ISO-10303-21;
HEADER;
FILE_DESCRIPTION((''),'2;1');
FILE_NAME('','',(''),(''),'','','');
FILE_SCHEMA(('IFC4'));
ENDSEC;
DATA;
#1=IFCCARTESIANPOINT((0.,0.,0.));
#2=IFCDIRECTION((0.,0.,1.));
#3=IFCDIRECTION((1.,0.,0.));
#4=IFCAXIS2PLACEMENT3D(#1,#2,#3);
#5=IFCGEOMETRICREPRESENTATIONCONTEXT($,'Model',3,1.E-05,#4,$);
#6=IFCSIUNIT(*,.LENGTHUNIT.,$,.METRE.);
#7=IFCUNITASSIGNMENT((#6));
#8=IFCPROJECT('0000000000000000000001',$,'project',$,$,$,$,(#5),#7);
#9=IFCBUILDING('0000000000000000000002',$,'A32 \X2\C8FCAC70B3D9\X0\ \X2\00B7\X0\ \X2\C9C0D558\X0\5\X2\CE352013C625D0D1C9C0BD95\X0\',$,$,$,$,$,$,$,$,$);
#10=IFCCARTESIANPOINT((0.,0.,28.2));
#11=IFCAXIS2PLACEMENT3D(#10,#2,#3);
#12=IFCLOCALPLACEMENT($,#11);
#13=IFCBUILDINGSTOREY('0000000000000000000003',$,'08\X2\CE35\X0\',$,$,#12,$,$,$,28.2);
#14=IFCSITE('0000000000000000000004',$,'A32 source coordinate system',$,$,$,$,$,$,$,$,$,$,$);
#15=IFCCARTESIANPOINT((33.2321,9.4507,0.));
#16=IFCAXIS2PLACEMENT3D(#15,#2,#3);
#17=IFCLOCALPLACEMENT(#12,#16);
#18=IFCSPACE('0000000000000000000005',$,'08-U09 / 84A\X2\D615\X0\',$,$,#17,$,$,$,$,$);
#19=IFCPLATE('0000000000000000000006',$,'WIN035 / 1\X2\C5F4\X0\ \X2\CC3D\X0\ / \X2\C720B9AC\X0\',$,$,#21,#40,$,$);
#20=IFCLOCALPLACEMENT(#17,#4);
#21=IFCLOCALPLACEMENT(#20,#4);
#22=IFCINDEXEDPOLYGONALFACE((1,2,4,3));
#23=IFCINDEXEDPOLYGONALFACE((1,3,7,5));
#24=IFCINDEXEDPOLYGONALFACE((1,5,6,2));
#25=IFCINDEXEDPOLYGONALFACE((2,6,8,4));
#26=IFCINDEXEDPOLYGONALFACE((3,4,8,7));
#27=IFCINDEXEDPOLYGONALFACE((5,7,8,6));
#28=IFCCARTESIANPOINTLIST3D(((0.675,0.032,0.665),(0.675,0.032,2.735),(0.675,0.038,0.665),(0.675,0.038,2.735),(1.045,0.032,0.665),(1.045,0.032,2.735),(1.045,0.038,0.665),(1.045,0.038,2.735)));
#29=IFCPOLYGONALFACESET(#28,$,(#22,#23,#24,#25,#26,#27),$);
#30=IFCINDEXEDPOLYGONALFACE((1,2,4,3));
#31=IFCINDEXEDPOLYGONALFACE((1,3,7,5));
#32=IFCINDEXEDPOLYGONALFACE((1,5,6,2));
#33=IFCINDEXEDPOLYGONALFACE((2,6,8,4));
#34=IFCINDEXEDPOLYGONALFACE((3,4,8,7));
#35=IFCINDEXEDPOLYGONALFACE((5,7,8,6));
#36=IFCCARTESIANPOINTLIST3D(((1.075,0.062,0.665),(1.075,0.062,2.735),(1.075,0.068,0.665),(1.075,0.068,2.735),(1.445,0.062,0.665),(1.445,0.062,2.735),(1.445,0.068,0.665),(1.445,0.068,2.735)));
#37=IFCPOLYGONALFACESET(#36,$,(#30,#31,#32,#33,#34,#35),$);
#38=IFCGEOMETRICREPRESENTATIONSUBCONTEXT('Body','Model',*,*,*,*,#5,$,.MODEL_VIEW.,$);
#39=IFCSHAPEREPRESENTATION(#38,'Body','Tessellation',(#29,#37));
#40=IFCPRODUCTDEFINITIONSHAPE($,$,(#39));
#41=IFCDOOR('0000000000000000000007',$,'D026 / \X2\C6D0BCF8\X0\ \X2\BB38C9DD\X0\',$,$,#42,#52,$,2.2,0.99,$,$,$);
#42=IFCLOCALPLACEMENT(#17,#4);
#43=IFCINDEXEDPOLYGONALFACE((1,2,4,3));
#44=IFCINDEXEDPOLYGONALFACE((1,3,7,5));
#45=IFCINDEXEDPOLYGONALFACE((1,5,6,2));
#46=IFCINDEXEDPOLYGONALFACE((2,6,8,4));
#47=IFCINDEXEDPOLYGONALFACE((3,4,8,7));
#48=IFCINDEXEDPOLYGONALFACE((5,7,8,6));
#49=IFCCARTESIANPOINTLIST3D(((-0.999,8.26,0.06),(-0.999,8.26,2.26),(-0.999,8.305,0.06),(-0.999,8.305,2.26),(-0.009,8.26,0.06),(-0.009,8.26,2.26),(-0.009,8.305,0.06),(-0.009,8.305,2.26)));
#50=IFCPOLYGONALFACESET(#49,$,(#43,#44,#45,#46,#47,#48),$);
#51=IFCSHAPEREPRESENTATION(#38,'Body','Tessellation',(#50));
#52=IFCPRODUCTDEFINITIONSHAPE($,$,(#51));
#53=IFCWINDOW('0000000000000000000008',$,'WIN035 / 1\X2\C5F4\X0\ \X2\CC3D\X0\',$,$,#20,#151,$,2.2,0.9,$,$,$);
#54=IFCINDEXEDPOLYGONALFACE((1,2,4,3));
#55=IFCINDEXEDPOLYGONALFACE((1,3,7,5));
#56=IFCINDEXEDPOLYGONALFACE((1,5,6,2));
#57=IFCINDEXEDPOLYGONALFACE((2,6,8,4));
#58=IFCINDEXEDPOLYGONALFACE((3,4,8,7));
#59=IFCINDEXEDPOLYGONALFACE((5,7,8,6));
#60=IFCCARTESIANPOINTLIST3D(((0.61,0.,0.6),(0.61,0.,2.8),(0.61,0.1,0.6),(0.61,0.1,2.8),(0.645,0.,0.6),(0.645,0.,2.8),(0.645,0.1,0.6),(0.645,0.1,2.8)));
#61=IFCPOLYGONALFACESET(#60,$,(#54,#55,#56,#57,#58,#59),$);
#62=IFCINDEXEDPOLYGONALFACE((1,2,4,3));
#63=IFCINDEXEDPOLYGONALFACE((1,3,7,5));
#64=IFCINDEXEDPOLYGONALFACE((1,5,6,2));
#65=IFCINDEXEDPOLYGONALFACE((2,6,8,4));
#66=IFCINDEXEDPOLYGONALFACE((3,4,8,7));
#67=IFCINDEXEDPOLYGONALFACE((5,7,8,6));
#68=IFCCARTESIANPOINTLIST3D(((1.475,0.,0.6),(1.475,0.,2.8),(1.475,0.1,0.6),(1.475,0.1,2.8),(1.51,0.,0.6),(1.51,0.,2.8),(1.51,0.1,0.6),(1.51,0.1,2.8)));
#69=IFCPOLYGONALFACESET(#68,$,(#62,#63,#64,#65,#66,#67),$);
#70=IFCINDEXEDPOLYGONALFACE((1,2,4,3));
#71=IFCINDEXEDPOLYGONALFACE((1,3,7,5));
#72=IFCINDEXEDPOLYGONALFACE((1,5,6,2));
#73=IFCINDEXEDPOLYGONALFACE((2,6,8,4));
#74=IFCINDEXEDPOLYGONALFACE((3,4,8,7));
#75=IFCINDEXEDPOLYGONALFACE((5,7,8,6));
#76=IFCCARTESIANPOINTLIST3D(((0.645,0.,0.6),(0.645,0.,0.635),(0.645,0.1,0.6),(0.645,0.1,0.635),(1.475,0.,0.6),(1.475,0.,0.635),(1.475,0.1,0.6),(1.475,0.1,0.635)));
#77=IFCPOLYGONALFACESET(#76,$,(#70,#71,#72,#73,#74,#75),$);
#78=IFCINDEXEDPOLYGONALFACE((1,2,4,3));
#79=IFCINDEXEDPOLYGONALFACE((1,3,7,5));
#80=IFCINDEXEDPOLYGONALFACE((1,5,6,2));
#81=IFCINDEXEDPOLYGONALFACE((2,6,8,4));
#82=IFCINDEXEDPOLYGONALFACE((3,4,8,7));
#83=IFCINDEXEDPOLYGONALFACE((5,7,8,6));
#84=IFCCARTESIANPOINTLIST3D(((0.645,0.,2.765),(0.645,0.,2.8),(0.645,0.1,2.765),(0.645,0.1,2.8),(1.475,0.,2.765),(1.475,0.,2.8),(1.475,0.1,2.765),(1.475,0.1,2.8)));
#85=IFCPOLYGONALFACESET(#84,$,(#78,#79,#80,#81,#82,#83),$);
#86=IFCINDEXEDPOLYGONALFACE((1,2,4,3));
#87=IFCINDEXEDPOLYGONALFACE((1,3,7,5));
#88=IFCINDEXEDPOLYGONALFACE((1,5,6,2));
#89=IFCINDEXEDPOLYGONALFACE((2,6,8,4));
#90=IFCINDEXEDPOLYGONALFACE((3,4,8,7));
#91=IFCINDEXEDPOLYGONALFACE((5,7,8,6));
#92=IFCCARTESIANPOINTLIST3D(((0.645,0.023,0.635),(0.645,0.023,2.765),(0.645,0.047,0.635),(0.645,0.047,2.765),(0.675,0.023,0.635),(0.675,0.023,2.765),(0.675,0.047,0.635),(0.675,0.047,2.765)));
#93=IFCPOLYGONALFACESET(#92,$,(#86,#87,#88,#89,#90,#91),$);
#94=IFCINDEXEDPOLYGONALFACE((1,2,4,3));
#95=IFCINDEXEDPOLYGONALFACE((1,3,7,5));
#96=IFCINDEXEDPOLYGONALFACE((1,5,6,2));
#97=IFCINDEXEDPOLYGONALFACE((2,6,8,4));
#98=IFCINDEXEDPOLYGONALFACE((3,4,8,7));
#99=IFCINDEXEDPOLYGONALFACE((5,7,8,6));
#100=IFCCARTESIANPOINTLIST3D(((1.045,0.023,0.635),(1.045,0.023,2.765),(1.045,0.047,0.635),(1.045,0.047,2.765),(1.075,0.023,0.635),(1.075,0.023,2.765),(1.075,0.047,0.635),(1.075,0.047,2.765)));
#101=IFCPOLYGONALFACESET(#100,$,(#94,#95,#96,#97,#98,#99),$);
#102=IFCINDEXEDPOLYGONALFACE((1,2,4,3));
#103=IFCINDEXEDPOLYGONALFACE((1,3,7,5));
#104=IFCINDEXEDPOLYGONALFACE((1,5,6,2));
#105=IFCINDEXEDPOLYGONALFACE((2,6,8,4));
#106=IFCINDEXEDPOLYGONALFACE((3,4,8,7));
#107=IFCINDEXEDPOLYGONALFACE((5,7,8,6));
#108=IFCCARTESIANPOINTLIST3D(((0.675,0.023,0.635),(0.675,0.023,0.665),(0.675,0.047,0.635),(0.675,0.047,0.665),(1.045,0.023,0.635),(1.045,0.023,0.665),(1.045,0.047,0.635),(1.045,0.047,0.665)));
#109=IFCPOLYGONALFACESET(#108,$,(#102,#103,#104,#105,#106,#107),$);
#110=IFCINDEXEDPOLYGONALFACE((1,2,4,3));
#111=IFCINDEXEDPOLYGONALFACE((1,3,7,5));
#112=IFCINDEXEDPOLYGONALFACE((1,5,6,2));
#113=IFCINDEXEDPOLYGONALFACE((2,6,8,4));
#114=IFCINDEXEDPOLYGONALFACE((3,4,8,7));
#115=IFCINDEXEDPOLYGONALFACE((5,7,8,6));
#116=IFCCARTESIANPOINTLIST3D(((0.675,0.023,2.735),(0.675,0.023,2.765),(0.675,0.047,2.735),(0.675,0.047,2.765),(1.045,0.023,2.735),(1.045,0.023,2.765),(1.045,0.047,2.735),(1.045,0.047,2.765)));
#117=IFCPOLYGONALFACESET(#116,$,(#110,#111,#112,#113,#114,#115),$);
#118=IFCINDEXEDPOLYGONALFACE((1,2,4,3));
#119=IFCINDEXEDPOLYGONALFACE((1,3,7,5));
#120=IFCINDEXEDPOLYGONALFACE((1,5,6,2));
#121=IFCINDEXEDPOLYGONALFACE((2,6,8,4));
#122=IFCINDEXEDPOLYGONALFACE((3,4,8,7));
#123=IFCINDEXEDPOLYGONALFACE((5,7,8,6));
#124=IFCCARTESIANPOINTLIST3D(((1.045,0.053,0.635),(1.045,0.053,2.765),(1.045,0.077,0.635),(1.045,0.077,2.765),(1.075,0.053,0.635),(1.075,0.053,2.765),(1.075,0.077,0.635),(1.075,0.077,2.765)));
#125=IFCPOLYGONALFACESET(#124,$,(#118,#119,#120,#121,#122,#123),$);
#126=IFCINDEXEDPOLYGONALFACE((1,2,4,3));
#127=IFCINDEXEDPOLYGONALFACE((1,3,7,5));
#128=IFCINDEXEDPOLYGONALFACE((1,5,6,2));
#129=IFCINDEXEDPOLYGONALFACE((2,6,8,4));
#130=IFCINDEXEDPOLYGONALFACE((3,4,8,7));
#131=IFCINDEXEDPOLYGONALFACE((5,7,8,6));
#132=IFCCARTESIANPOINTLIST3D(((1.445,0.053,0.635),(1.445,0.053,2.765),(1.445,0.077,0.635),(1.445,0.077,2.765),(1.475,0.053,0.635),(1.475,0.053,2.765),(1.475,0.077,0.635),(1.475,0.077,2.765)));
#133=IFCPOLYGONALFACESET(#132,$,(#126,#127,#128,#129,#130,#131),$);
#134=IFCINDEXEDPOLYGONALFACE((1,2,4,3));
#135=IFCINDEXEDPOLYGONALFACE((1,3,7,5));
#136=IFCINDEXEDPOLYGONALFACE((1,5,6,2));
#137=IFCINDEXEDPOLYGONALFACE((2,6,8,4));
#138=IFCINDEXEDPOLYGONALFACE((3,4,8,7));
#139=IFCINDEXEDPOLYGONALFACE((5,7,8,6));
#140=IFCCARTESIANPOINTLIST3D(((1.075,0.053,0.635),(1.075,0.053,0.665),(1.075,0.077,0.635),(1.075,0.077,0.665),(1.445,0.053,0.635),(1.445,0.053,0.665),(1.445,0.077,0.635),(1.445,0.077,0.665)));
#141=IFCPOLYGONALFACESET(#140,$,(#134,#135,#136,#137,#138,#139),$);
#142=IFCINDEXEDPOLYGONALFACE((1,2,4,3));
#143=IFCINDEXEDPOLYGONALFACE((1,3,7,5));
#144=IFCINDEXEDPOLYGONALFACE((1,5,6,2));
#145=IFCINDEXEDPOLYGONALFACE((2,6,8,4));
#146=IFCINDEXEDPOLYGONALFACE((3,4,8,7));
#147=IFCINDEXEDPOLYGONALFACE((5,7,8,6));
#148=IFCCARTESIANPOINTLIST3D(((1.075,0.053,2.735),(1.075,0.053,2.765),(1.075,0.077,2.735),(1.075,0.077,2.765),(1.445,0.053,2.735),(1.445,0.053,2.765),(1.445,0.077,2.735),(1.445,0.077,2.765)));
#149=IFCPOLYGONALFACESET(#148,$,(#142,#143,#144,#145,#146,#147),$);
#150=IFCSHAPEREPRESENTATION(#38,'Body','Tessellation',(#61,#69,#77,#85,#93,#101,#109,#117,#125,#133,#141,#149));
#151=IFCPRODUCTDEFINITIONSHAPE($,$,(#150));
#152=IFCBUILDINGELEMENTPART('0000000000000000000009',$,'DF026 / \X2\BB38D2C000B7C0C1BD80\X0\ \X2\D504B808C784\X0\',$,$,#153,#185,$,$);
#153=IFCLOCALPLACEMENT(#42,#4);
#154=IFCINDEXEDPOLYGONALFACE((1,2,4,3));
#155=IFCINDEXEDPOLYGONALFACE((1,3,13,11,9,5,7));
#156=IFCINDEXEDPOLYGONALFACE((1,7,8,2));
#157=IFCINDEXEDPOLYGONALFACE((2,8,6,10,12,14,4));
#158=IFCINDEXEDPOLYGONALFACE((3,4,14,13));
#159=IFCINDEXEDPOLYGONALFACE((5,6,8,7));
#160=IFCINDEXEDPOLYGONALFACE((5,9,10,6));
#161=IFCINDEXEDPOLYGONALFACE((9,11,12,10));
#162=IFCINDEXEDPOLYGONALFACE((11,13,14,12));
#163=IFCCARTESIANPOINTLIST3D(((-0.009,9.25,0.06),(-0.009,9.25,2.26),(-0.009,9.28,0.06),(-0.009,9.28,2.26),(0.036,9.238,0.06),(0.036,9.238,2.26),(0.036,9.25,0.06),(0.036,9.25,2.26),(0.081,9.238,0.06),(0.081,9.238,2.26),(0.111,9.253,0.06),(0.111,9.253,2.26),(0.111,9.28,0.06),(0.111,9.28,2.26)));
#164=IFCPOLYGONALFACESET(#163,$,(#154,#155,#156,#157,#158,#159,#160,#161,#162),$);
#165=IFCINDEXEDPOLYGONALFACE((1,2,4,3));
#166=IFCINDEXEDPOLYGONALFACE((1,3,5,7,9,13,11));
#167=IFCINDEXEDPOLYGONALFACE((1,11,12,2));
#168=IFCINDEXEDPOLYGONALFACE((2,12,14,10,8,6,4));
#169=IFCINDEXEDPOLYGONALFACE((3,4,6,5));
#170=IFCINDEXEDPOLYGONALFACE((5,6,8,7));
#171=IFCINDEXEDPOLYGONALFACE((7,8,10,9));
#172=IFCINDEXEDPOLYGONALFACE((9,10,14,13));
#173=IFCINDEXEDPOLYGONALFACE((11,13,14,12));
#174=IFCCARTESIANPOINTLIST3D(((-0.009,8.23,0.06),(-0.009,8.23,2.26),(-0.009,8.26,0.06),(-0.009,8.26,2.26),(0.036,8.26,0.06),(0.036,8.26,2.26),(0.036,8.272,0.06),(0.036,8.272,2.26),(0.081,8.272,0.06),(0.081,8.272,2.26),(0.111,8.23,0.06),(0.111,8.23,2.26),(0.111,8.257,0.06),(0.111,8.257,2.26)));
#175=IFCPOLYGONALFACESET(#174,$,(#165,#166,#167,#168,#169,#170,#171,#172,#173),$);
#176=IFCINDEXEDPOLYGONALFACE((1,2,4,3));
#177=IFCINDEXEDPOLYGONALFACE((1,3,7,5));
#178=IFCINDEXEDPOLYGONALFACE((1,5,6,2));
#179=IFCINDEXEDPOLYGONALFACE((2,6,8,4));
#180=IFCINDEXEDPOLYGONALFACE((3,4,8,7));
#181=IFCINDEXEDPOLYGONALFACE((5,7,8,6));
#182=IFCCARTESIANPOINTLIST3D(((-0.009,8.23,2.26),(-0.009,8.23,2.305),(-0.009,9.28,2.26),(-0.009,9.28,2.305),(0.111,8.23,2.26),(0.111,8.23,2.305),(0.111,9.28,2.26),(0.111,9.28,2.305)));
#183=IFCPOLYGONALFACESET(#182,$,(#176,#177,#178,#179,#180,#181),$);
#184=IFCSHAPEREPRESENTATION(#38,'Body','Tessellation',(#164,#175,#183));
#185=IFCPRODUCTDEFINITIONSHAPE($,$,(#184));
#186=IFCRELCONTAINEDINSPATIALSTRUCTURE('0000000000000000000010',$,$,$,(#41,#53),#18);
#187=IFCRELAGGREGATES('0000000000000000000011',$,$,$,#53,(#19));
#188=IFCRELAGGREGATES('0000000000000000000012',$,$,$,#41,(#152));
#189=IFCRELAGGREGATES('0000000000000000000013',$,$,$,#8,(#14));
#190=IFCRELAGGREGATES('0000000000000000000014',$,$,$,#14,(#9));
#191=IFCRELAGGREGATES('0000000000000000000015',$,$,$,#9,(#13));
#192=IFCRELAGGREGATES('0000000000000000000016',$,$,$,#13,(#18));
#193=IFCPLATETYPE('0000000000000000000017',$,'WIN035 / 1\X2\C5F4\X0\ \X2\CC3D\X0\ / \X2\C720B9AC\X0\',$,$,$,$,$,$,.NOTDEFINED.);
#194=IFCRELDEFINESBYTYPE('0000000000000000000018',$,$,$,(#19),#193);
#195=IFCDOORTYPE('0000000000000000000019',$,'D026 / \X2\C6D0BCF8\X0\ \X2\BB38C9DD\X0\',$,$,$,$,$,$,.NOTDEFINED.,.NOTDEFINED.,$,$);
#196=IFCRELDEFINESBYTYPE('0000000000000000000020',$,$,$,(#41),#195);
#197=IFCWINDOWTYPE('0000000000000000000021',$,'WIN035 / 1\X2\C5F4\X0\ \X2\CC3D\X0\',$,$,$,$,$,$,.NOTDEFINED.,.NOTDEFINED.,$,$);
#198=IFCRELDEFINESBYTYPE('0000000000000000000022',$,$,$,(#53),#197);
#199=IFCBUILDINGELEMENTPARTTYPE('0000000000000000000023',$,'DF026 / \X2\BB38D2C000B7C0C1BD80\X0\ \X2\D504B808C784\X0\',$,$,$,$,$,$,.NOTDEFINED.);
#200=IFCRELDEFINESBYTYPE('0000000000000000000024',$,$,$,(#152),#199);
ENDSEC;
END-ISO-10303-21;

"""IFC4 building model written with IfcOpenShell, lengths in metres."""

from ifc_helpers import new_model, si_unit, frame, origin, origin_with_axes, place, context, subcontext, project, spatial, polyline, outline, extrude, source, transform, mapped, type_object, type_shapes, element, aggregate, save


model = new_model("IFC4")

# Units and contexts
model_context = context("Model", 3, precision=1e-05, world=origin_with_axes())
body_context = subcontext(model_context, "Body", "Model", "MODEL_VIEW")
ifc_project = project(units=[si_unit("LENGTHUNIT", "METRE")], contexts=[model_context])

# Plate
plate_type_1 = type_object("IfcPlateType", Name="WIN035 / 1열 창 / 유리", PredefinedType="NOTDEFINED")
shared_shape_1 = source(origin(), body_context, "Body", "SweptSolid", [
    extrude(outline(polyline([(0.675, 0.032), (0.675, 0.038), (1.045, 0.038), (1.045, 0.032), (0.675, 0.032)])), frame((0.0, 0.0, 0.665)), (0.0, 0.0, 1.0), 2.07),
    extrude(outline(polyline([(1.075, 0.062), (1.075, 0.068), (1.445, 0.068), (1.445, 0.062), (1.075, 0.062)])), frame((0.0, 0.0, 0.665)), (0.0, 0.0, 1.0), 2.07),
])
type_shapes(plate_type_1, [shared_shape_1])
storey_placement = place(None, frame((0.0, 0.0, 28.2), z_axis=(0.0, 0.0, 1.0), x_axis=(1.0, 0.0, 0.0)))
space_placement = place(storey_placement, frame((33.2321, 9.4507, 0.0), z_axis=(0.0, 0.0, 1.0), x_axis=(1.0, 0.0, 0.0)))
window_1_placement = place(space_placement, origin_with_axes())
plate_1_placement = place(window_1_placement, origin_with_axes())
plate_1 = element("IfcPlate", 1, at=plate_1_placement, type_object=plate_type_1, Name="WIN035 / 1열 창 / 유리", context=body_context, shape_type="MappedRepresentation", body=[
    mapped(shared_shape_1, transform((0.0, 0.0, 0.0), scale=1.0)),
])

# Site, building, storey, space
site = spatial("IfcSite", under=ifc_project, Name="A32 source coordinate system")
building = spatial("IfcBuilding", under=site, Name="A32 주거동 · 지하5층–옥탑지붕")
storey = spatial("IfcBuildingStorey", under=building, at=storey_placement, Name="08층", Elevation=28.2)
space = spatial("IfcSpace", under=storey, at=space_placement, Name="08-U09 / 84A형")

# Door
door_type_1 = type_object("IfcDoorType", Name="D026 / 원본 문짝", OperationType="NOTDEFINED", PredefinedType="NOTDEFINED")
shared_shape_2 = source(origin(), body_context, "Body", "SweptSolid", [
    extrude(outline(polyline([(-0.009, 8.26), (-0.999, 8.26), (-0.999, 8.305), (-0.009, 8.305), (-0.009, 8.26)])), frame((0.0, 0.0, 0.06)), (0.0, 0.0, 1.0), 2.2),
])
type_shapes(door_type_1, [shared_shape_2])
door_1_placement = place(space_placement, origin_with_axes())
door_1 = element("IfcDoor", 2, at=door_1_placement, inside=space, type_object=door_type_1, Name="D026 / 원본 문짝", OverallHeight=2.2, OverallWidth=0.99, context=body_context, shape_type="MappedRepresentation", body=[
    mapped(shared_shape_2, transform((0.0, 0.0, 0.0), scale=1.0)),
])

# Window
window_type_1 = type_object("IfcWindowType", Name="WIN035 / 1열 창", PartitioningType="NOTDEFINED", PredefinedType="NOTDEFINED")
shared_shape_3 = source(origin(), body_context, "Body", "SweptSolid", [
    extrude(outline(polyline([(0.61, 0.0), (0.61, 0.1), (0.645, 0.1), (0.645, 0.0), (0.61, 0.0)])), frame((0.0, 0.0, 0.6)), (0.0, 0.0, 1.0), 2.2),
    extrude(outline(polyline([(1.475, 0.0), (1.475, 0.1), (1.51, 0.1), (1.51, 0.0), (1.475, 0.0)])), frame((0.0, 0.0, 0.6)), (0.0, 0.0, 1.0), 2.2),
    extrude(outline(polyline([(0.645, 0.0), (0.645, 0.1), (1.475, 0.1), (1.475, 0.0), (0.645, 0.0)])), frame((0.0, 0.0, 0.6)), (0.0, 0.0, 1.0), 0.035),
    extrude(outline(polyline([(0.645, 0.0), (0.645, 0.1), (1.475, 0.1), (1.475, 0.0), (0.645, 0.0)])), frame((0.0, 0.0, 2.765)), (0.0, 0.0, 1.0), 0.035),
    extrude(outline(polyline([(0.645, 0.023), (0.645, 0.047), (0.675, 0.047), (0.675, 0.023), (0.645, 0.023)])), frame((0.0, 0.0, 0.635)), (0.0, 0.0, 1.0), 2.13),
    extrude(outline(polyline([(1.045, 0.023), (1.045, 0.047), (1.075, 0.047), (1.075, 0.023), (1.045, 0.023)])), frame((0.0, 0.0, 0.635)), (0.0, 0.0, 1.0), 2.13),
    extrude(outline(polyline([(0.675, 0.023), (0.675, 0.047), (1.045, 0.047), (1.045, 0.023), (0.675, 0.023)])), frame((0.0, 0.0, 0.635)), (0.0, 0.0, 1.0), 0.03),
    extrude(outline(polyline([(0.675, 0.023), (0.675, 0.047), (1.045, 0.047), (1.045, 0.023), (0.675, 0.023)])), frame((0.0, 0.0, 2.735)), (0.0, 0.0, 1.0), 0.03),
    extrude(outline(polyline([(1.045, 0.053), (1.045, 0.077), (1.075, 0.077), (1.075, 0.053), (1.045, 0.053)])), frame((0.0, 0.0, 0.635)), (0.0, 0.0, 1.0), 2.13),
    extrude(outline(polyline([(1.445, 0.053), (1.445, 0.077), (1.475, 0.077), (1.475, 0.053), (1.445, 0.053)])), frame((0.0, 0.0, 0.635)), (0.0, 0.0, 1.0), 2.13),
    extrude(outline(polyline([(1.075, 0.053), (1.075, 0.077), (1.445, 0.077), (1.445, 0.053), (1.075, 0.053)])), frame((0.0, 0.0, 0.635)), (0.0, 0.0, 1.0), 0.03),
    extrude(outline(polyline([(1.075, 0.053), (1.075, 0.077), (1.445, 0.077), (1.445, 0.053), (1.075, 0.053)])), frame((0.0, 0.0, 2.735)), (0.0, 0.0, 1.0), 0.03),
])
type_shapes(window_type_1, [shared_shape_3])
window_1 = element("IfcWindow", 3, at=window_1_placement, inside=space, type_object=window_type_1, Name="WIN035 / 1열 창", OverallHeight=2.2, OverallWidth=0.9, context=body_context, shape_type="MappedRepresentation", body=[
    mapped(shared_shape_3, transform((0.0, 0.0, 0.0), scale=1.0)),
])
aggregate(window_1, [plate_1])

# Building element part
building_element_part_type_1 = type_object("IfcBuildingElementPartType", Name="DF026 / 문틀·상부 프레임", PredefinedType="NOTDEFINED")
shared_shape_4 = source(origin(), body_context, "Body", "SweptSolid", [
    extrude(outline(polyline([(0.111, 9.28), (0.111, 9.253), (0.081, 9.238), (0.036, 9.238), (0.036, 9.25), (-0.009, 9.25), (-0.009, 9.28), (0.111, 9.28)])), frame((0.0, 0.0, 0.06)), (0.0, 0.0, 1.0), 2.2),
    extrude(outline(polyline([(-0.009, 8.26), (0.036, 8.26), (0.036, 8.272), (0.081, 8.272), (0.111, 8.257), (0.111, 8.23), (-0.009, 8.23), (-0.009, 8.26)])), frame((0.0, 0.0, 0.06)), (0.0, 0.0, 1.0), 2.2),
    extrude(outline(polyline([(-0.009, 8.23), (-0.009, 9.28), (0.111, 9.28), (0.111, 8.23), (-0.009, 8.23)])), frame((0.0, 0.0, 2.26)), (0.0, 0.0, 1.0), 0.045),
])
type_shapes(building_element_part_type_1, [shared_shape_4])
building_element_part_1_placement = place(door_1_placement, origin_with_axes())
building_element_part_1 = element("IfcBuildingElementPart", 4, at=building_element_part_1_placement, type_object=building_element_part_type_1, Name="DF026 / 문틀·상부 프레임", context=body_context, shape_type="MappedRepresentation", body=[
    mapped(shared_shape_4, transform((0.0, 0.0, 0.0), scale=1.0)),
])
aggregate(door_1, [building_element_part_1])

save(model, "model.ifc")
